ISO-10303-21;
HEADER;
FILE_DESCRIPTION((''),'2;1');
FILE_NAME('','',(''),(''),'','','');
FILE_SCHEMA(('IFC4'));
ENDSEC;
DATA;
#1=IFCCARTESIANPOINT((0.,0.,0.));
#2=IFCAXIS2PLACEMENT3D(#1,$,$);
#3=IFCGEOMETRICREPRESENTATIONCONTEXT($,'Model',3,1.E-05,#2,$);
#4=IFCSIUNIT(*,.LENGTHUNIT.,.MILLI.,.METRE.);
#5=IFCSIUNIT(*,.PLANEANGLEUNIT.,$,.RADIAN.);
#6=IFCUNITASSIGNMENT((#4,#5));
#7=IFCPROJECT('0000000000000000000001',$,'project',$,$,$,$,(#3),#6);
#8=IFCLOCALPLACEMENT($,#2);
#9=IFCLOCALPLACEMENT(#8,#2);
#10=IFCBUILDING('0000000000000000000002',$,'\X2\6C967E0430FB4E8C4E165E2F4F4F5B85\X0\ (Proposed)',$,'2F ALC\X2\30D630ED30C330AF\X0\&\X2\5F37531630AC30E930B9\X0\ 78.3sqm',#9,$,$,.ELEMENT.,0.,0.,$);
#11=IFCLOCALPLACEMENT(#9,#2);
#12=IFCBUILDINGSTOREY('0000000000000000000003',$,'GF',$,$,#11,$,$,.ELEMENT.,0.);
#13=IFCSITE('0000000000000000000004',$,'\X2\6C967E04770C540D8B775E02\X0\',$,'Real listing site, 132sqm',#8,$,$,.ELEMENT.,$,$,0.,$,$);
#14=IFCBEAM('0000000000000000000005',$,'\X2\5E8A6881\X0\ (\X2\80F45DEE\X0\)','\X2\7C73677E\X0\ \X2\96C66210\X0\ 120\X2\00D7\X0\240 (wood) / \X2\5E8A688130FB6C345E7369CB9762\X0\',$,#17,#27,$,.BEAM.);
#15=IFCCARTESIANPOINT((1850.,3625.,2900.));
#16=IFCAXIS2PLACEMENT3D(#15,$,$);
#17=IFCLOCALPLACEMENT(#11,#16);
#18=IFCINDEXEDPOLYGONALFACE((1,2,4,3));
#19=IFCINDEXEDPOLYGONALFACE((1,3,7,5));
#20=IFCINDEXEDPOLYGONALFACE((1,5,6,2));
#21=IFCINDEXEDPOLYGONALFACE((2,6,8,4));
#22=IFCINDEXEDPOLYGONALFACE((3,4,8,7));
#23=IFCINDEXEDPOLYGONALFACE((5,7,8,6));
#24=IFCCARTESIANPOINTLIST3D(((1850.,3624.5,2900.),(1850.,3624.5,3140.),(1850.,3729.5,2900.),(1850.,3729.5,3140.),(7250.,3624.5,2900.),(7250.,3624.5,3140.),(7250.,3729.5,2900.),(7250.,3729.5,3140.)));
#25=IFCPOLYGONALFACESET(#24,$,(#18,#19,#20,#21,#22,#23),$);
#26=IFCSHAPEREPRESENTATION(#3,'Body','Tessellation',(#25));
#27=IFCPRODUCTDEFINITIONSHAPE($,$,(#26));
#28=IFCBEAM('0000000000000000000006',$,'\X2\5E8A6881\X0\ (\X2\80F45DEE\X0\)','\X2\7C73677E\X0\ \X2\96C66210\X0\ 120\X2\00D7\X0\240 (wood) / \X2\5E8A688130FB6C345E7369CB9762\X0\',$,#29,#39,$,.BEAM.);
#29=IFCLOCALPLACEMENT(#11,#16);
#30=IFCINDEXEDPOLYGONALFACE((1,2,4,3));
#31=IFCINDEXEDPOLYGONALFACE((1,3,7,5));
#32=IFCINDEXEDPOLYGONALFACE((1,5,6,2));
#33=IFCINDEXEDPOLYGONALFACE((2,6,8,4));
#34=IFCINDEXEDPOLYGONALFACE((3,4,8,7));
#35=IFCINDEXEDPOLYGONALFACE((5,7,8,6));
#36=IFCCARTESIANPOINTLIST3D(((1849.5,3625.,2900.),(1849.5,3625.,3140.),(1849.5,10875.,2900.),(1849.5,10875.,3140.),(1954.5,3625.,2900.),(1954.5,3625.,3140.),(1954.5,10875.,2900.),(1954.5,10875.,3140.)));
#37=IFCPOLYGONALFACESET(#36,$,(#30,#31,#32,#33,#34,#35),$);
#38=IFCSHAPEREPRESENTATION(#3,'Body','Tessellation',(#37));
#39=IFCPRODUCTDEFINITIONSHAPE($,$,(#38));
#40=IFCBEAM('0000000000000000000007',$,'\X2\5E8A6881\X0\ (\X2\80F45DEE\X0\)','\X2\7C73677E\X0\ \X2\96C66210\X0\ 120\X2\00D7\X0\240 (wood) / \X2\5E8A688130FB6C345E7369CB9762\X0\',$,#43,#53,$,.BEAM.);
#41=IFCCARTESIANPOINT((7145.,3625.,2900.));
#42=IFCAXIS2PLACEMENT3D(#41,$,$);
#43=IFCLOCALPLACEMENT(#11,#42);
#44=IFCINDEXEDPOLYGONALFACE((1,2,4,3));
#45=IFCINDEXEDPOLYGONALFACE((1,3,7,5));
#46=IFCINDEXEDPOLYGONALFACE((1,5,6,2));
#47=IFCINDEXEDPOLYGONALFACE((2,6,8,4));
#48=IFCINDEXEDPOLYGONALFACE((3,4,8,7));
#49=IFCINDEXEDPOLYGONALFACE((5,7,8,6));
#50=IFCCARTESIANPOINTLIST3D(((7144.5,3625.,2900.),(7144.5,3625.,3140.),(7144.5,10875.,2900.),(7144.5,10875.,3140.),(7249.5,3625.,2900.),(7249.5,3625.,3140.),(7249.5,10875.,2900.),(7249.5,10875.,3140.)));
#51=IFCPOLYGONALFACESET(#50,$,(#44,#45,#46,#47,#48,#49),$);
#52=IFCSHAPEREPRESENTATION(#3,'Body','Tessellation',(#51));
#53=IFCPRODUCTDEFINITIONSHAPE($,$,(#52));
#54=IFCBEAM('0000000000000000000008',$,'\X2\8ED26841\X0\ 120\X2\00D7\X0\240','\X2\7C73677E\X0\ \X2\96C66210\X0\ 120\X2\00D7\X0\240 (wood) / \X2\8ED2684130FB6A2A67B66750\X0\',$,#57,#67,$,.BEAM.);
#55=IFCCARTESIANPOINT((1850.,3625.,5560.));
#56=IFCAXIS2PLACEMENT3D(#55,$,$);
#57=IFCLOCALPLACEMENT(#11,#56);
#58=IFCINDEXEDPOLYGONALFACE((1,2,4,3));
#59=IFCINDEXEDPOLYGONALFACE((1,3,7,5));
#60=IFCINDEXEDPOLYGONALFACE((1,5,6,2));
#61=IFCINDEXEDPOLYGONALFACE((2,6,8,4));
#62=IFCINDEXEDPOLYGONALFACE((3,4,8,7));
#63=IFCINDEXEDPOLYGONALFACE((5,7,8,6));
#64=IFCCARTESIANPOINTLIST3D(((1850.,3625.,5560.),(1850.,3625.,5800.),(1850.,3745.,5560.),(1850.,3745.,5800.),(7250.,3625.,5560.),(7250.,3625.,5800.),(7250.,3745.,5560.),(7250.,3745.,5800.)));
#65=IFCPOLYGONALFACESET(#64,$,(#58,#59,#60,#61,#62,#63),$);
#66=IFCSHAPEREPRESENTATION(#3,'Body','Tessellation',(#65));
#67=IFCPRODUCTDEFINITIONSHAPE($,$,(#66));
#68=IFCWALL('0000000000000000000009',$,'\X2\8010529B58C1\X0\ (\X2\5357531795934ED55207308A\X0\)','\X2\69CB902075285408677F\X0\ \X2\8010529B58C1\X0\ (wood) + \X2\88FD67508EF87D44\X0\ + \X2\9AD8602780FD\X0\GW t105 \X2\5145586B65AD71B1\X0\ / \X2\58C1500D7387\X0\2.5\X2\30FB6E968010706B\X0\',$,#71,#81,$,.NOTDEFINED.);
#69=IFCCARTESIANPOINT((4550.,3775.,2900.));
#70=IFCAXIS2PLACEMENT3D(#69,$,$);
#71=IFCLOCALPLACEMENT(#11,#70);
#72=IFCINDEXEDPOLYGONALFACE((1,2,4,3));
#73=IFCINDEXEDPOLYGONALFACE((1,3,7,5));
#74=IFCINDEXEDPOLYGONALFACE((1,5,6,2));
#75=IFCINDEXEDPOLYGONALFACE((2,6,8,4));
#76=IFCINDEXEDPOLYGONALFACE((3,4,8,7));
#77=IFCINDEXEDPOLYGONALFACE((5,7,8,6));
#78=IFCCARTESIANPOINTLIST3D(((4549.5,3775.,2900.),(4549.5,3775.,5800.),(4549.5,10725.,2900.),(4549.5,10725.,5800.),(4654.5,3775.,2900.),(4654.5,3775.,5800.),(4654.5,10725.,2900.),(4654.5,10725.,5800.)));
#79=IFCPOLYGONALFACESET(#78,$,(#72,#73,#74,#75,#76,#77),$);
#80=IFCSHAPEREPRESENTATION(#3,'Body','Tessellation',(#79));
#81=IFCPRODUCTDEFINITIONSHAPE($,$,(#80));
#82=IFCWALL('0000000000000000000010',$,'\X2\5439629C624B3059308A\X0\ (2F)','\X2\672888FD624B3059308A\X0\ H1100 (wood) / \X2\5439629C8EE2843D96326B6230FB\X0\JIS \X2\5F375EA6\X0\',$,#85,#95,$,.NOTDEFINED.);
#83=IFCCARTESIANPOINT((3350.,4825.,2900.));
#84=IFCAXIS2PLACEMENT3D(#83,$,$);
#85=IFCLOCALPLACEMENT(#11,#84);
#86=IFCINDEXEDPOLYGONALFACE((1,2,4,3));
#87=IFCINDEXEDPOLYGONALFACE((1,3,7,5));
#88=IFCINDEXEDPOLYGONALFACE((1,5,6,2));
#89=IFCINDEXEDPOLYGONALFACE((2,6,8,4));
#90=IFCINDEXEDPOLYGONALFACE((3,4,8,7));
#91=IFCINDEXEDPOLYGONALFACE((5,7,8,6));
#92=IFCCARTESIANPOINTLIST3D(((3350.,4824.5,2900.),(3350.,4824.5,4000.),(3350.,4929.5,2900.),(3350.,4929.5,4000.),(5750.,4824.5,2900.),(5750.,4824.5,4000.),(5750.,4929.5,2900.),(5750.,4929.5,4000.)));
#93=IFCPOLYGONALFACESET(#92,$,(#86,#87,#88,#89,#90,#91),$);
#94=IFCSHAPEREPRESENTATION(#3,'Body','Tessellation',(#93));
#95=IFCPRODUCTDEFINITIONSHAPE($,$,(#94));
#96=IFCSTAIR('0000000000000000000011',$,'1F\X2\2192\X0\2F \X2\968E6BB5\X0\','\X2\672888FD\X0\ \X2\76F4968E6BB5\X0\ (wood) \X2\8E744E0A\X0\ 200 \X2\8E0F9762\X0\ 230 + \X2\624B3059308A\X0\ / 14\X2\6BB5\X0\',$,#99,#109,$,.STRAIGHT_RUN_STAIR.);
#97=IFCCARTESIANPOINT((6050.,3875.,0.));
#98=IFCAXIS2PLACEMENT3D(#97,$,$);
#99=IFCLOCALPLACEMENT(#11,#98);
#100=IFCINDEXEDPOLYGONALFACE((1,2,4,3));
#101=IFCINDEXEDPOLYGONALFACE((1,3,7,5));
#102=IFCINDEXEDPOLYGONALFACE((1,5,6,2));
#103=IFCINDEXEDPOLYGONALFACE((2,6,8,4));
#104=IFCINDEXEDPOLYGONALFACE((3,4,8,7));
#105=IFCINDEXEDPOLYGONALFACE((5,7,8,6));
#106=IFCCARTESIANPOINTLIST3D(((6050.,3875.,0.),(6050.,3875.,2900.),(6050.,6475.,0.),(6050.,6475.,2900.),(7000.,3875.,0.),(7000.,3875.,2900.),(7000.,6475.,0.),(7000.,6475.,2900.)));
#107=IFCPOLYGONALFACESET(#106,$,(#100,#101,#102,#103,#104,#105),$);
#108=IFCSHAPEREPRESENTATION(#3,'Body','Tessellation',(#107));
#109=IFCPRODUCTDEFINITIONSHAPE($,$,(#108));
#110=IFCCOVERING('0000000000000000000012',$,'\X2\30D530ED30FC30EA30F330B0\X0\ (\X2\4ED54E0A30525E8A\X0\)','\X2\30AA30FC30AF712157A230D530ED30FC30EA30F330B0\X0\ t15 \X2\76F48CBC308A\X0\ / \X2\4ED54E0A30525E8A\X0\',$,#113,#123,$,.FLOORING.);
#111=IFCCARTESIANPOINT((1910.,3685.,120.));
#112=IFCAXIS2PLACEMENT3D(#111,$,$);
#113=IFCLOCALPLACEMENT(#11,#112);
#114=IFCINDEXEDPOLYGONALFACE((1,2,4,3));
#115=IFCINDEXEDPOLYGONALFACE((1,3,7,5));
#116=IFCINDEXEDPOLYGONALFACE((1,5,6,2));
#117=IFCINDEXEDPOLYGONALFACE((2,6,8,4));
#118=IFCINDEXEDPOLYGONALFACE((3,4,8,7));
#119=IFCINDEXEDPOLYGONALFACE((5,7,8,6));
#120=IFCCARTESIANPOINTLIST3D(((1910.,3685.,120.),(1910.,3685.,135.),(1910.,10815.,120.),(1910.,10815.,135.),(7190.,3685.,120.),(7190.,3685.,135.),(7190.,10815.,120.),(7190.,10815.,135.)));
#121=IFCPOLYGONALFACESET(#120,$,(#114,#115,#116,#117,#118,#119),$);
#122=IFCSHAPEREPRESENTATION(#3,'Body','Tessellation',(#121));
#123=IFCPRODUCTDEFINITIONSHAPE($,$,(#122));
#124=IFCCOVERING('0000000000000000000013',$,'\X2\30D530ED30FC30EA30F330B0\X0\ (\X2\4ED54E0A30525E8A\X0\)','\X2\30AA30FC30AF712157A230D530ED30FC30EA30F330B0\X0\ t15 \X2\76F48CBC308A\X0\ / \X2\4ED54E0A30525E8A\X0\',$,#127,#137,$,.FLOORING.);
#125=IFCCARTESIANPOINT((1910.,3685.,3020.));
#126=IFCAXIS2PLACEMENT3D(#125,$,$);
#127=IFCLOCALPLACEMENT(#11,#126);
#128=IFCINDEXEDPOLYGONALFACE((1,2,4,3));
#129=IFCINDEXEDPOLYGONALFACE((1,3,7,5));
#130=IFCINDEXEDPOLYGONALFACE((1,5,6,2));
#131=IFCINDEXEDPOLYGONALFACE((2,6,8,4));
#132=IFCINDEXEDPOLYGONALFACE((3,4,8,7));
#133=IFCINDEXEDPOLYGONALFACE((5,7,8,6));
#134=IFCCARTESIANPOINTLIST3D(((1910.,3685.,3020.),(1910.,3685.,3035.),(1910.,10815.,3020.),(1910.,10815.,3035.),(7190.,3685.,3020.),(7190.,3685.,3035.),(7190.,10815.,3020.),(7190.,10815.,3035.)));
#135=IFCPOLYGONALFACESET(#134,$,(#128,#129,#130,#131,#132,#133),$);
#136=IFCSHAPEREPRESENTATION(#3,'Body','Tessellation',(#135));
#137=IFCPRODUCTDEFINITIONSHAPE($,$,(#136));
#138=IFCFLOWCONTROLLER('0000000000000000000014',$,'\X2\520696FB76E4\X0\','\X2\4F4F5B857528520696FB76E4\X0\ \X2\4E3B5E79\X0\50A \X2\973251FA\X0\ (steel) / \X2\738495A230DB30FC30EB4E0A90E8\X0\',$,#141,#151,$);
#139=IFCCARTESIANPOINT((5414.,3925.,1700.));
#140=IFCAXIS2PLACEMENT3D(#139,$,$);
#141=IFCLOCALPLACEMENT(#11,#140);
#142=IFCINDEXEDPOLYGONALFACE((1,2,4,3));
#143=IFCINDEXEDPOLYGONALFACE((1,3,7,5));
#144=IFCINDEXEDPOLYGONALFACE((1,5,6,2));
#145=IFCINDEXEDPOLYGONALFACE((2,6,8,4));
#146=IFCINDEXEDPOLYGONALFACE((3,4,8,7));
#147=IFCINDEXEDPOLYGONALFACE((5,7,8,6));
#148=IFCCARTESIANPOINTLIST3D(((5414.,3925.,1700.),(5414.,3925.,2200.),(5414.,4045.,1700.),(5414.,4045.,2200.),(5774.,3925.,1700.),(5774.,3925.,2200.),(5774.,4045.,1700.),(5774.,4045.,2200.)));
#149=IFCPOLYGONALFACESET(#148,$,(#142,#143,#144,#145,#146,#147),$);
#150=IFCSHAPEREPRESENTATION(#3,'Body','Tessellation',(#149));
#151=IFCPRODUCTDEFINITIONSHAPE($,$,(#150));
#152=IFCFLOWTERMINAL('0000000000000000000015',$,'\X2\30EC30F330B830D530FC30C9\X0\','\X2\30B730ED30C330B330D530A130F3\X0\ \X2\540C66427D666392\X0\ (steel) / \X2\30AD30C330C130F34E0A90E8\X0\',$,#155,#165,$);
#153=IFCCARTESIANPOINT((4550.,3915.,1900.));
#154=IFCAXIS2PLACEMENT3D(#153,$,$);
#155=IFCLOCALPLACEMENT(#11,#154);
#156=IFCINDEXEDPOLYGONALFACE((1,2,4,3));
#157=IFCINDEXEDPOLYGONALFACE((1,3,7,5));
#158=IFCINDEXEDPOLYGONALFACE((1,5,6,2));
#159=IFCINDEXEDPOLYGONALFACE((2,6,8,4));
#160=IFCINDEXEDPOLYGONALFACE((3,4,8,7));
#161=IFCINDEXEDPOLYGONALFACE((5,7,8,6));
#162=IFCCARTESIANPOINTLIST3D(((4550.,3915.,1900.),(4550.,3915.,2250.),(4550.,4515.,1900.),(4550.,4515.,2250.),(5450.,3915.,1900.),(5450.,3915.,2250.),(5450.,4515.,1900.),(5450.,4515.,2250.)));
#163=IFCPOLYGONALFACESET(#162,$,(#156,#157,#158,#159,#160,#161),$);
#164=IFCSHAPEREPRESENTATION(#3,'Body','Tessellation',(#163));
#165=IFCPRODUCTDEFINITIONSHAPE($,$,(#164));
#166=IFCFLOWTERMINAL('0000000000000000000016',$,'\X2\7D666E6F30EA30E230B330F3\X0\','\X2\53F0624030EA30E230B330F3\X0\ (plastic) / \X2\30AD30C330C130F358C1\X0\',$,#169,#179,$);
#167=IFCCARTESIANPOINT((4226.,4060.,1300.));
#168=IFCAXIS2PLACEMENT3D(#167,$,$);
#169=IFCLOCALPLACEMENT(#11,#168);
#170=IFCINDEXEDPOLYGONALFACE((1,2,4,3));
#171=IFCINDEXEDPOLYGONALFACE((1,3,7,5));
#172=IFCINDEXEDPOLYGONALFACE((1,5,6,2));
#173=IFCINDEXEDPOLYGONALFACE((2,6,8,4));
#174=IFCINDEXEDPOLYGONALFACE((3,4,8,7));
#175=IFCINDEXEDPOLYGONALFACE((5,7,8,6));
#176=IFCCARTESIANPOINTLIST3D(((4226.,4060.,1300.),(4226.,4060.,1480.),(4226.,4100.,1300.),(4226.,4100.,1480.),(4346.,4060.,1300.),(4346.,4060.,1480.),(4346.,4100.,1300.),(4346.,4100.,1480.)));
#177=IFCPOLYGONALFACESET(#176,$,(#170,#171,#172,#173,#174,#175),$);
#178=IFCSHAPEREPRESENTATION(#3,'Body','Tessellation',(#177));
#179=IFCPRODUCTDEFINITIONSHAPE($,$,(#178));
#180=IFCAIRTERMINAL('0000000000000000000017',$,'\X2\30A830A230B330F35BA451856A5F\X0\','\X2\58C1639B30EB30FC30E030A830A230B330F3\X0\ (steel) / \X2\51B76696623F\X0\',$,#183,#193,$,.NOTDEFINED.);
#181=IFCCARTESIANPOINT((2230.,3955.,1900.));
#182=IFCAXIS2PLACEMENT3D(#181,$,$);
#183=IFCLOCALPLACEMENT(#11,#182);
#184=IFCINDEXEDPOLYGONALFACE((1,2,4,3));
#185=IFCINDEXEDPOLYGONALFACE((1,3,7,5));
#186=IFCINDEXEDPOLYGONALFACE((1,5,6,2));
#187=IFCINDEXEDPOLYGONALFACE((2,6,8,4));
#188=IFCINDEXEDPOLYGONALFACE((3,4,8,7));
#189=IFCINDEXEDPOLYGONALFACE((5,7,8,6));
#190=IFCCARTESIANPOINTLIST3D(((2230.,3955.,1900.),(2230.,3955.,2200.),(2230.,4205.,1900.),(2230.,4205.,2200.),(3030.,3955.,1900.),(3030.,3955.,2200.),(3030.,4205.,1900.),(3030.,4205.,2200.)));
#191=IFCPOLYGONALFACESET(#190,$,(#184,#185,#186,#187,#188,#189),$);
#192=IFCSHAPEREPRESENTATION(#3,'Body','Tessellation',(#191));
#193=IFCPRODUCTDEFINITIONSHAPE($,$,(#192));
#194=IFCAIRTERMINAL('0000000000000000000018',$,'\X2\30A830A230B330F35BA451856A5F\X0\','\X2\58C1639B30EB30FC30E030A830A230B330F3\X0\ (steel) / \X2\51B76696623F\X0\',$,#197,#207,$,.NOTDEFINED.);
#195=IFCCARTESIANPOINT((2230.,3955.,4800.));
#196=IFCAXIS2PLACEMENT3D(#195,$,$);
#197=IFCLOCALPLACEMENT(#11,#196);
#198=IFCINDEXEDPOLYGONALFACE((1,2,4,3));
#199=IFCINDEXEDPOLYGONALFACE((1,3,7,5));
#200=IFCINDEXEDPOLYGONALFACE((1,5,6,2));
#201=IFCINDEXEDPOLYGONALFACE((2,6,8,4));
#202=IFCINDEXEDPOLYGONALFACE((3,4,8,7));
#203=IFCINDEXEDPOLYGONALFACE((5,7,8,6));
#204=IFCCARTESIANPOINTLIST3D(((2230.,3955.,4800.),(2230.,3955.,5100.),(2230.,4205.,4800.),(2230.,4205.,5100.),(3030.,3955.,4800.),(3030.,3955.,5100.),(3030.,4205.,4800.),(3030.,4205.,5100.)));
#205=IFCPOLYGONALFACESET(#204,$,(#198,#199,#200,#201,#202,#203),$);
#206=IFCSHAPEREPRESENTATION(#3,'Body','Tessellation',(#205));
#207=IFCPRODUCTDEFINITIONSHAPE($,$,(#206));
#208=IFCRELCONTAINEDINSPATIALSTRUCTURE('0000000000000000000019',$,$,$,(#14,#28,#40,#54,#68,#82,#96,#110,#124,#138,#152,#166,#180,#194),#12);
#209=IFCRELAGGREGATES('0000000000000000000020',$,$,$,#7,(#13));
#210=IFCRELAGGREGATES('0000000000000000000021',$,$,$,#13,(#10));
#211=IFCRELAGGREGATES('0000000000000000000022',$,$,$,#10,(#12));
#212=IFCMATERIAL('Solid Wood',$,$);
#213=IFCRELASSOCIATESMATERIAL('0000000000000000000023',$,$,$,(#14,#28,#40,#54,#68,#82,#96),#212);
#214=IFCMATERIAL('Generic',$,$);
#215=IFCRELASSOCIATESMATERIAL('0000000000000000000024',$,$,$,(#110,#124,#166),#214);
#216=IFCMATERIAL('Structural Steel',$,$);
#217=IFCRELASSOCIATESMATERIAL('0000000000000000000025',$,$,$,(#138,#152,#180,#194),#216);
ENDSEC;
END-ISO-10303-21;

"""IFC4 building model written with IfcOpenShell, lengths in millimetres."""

from ifc_helpers import new_model, si_unit, frame, frame_2d, origin, place, context, project, spatial, rectangle, extrude, material, element, save


model = new_model("IFC4")

# Units and contexts
model_context = context("Model", 3, precision=1e-05, world=origin())
ifc_project = project(units=[si_unit("LENGTHUNIT", "METRE", prefix="MILLI"), si_unit("PLANEANGLEUNIT", "RADIAN")], contexts=[model_context])

# Site, building, storey
site_placement = place(None, origin())
site = spatial("IfcSite", under=ifc_project, at=site_placement, Name="沖縄県名護市", ObjectType="Real listing site, 132sqm", CompositionType="ELEMENT", RefElevation=0.0)
building_placement = place(site_placement, origin())
building = spatial("IfcBuilding", under=site, at=building_placement, Name="沖縄・二世帯住宅 (Proposed)", ObjectType="2F ALCブロック&強化ガラス 78.3sqm", CompositionType="ELEMENT", ElevationOfRefHeight=0.0, ElevationOfTerrain=0.0)
storey_placement = place(building_placement, origin())
storey = spatial("IfcBuildingStorey", under=building, at=storey_placement, Name="GF", CompositionType="ELEMENT", Elevation=0.0)

# Shared definitions
ifc_material_1 = material(Name="Solid Wood")

# Beams
beam_1_placement = place(storey_placement, frame((1850.0, 3625.0, 2900.0)))
element("IfcBeam", 1, at=beam_1_placement, inside=storey, material=ifc_material_1, Name="床梁 (胴差)", Description="米松 集成 120×240 (wood) / 床梁・水平構面", PredefinedType="BEAM", context=model_context, shape_type="SweptSolid", body=[
    extrude(rectangle(XDim=5400.0, YDim=105.0, at=frame_2d((2700.0, 52.0))), frame((1850.0, 3625.0, 2900.0)), (0.0, 0.0, 1.0), 240.0),
])
beam_2_placement = place(storey_placement, frame((1850.0, 3625.0, 2900.0)))
element("IfcBeam", 2, at=beam_2_placement, inside=storey, material=ifc_material_1, Name="床梁 (胴差)", Description="米松 集成 120×240 (wood) / 床梁・水平構面", PredefinedType="BEAM", context=model_context, shape_type="SweptSolid", body=[
    extrude(rectangle(XDim=105.0, YDim=7250.0, at=frame_2d((52.0, 3625.0))), frame((1850.0, 3625.0, 2900.0)), (0.0, 0.0, 1.0), 240.0),
])
beam_3_placement = place(storey_placement, frame((7145.0, 3625.0, 2900.0)))
element("IfcBeam", 3, at=beam_3_placement, inside=storey, material=ifc_material_1, Name="床梁 (胴差)", Description="米松 集成 120×240 (wood) / 床梁・水平構面", PredefinedType="BEAM", context=model_context, shape_type="SweptSolid", body=[
    extrude(rectangle(XDim=105.0, YDim=7250.0, at=frame_2d((52.0, 3625.0))), frame((7145.0, 3625.0, 2900.0)), (0.0, 0.0, 1.0), 240.0),
])
beam_4_placement = place(storey_placement, frame((1850.0, 3625.0, 5560.0)))
element("IfcBeam", 4, at=beam_4_placement, inside=storey, material=ifc_material_1, Name="軒桁 120×240", Description="米松 集成 120×240 (wood) / 軒桁・横架材", PredefinedType="BEAM", context=model_context, shape_type="SweptSolid", body=[
    extrude(rectangle(XDim=5400.0, YDim=120.0, at=frame_2d((2700.0, 60.0))), frame((1850.0, 3625.0, 5560.0)), (0.0, 0.0, 1.0), 240.0),
])

# Walls
wall_1_placement = place(storey_placement, frame((4550.0, 3775.0, 2900.0)))
element("IfcWall", 5, at=wall_1_placement, inside=storey, material=ifc_material_1, Name="耐力壁 (南北間仕切り)", Description="構造用合板 耐力壁 (wood) + 製材軸組 + 高性能GW t105 充填断熱 / 壁倍率2.5・準耐火", PredefinedType="NOTDEFINED", context=model_context, shape_type="SweptSolid", body=[
    extrude(rectangle(XDim=105.0, YDim=6950.0, at=frame_2d((52.0, 3475.0))), frame((4550.0, 3775.0, 2900.0)), (0.0, 0.0, 1.0), 2900.0),
])
wall_2_placement = place(storey_placement, frame((3350.0, 4825.0, 2900.0)))
element("IfcWall", 6, at=wall_2_placement, inside=storey, material=ifc_material_1, Name="吹抜手すり (2F)", Description="木製手すり H1100 (wood) / 吹抜転落防止・JIS 強度", PredefinedType="NOTDEFINED", context=model_context, shape_type="SweptSolid", body=[
    extrude(rectangle(XDim=2400.0, YDim=105.0, at=frame_2d((1200.0, 52.0))), frame((3350.0, 4825.0, 2900.0)), (0.0, 0.0, 1.0), 1100.0),
])

# Stair
stair_placement = place(storey_placement, frame((6050.0, 3875.0, 0.0)))
element("IfcStair", 7, at=stair_placement, inside=storey, material=ifc_material_1, Name="1F→2F 階段", Description="木製 直階段 (wood) 蹴上 200 踏面 230 + 手すり / 14段", PredefinedType="STRAIGHT_RUN_STAIR", context=model_context, shape_type="SweptSolid", body=[
    extrude(rectangle(XDim=950.0, YDim=2600.0, at=frame_2d((475.0, 1300.0))), frame((6050.0, 3875.0, 0.0)), (0.0, 0.0, 1.0), 2900.0),
])

# Coverings
ifc_material_2 = material(Name="Generic")
covering_1_placement = place(storey_placement, frame((1910.0, 3685.0, 120.0)))
element("IfcCovering", 8, at=covering_1_placement, inside=storey, material=ifc_material_2, Name="フローリング (仕上げ床)", Description="オーク無垢フローリング t15 直貼り / 仕上げ床", PredefinedType="FLOORING", context=model_context, shape_type="SweptSolid", body=[
    extrude(rectangle(XDim=5280.0, YDim=7130.0, at=frame_2d((2640.0, 3565.0))), frame((1910.0, 3685.0, 120.0)), (0.0, 0.0, 1.0), 15.0),
])
covering_2_placement = place(storey_placement, frame((1910.0, 3685.0, 3020.0)))
element("IfcCovering", 9, at=covering_2_placement, inside=storey, material=ifc_material_2, Name="フローリング (仕上げ床)", Description="オーク無垢フローリング t15 直貼り / 仕上げ床", PredefinedType="FLOORING", context=model_context, shape_type="SweptSolid", body=[
    extrude(rectangle(XDim=5280.0, YDim=7130.0, at=frame_2d((2640.0, 3565.0))), frame((1910.0, 3685.0, 3020.0)), (0.0, 0.0, 1.0), 15.0),
])

# Flow controller
ifc_material_3 = material(Name="Structural Steel")
flow_controller_placement = place(storey_placement, frame((5414.0, 3925.0, 1700.0)))
element("IfcFlowController", 10, at=flow_controller_placement, inside=storey, material=ifc_material_3, Name="分電盤", Description="住宅用分電盤 主幹50A 露出 (steel) / 玄関ホール上部", context=model_context, shape_type="SweptSolid", body=[
    extrude(rectangle(XDim=360.0, YDim=120.0, at=frame_2d((180.0, 60.0))), frame((5414.0, 3925.0, 1700.0)), (0.0, 0.0, 1.0), 500.0),
])

# Flow terminals
flow_terminal_1_placement = place(storey_placement, frame((4550.0, 3915.0, 1900.0)))
element("IfcFlowTerminal", 11, at=flow_terminal_1_placement, inside=storey, material=ifc_material_3, Name="レンジフード", Description="シロッコファン 同時給排 (steel) / キッチン上部", context=model_context, shape_type="SweptSolid", body=[
    extrude(rectangle(XDim=900.0, YDim=600.0, at=frame_2d((450.0, 300.0))), frame((4550.0, 3915.0, 1900.0)), (0.0, 0.0, 1.0), 350.0),
])
flow_terminal_2_placement = place(storey_placement, frame((4226.0, 4060.0, 1300.0)))
element("IfcFlowTerminal", 12, at=flow_terminal_2_placement, inside=storey, material=ifc_material_2, Name="給湯リモコン", Description="台所リモコン (plastic) / キッチン壁", context=model_context, shape_type="SweptSolid", body=[
    extrude(rectangle(XDim=120.0, YDim=40.0, at=frame_2d((60.0, 20.0))), frame((4226.0, 4060.0, 1300.0)), (0.0, 0.0, 1.0), 180.0),
])

# Air terminals
air_terminal_1_placement = place(storey_placement, frame((2230.0, 3955.0, 1900.0)))
element("IfcAirTerminal", 13, at=air_terminal_1_placement, inside=storey, material=ifc_material_3, Name="エアコン室内機", Description="壁掛ルームエアコン (steel) / 冷暖房", PredefinedType="NOTDEFINED", context=model_context, shape_type="SweptSolid", body=[
    extrude(rectangle(XDim=800.0, YDim=250.0, at=frame_2d((400.0, 125.0))), frame((2230.0, 3955.0, 1900.0)), (0.0, 0.0, 1.0), 300.0),
])
air_terminal_2_placement = place(storey_placement, frame((2230.0, 3955.0, 4800.0)))
element("IfcAirTerminal", 14, at=air_terminal_2_placement, inside=storey, material=ifc_material_3, Name="エアコン室内機", Description="壁掛ルームエアコン (steel) / 冷暖房", PredefinedType="NOTDEFINED", context=model_context, shape_type="SweptSolid", body=[
    extrude(rectangle(XDim=800.0, YDim=250.0, at=frame_2d((400.0, 125.0))), frame((2230.0, 3955.0, 4800.0)), (0.0, 0.0, 1.0), 300.0),
])

save(model, "model.ifc")
